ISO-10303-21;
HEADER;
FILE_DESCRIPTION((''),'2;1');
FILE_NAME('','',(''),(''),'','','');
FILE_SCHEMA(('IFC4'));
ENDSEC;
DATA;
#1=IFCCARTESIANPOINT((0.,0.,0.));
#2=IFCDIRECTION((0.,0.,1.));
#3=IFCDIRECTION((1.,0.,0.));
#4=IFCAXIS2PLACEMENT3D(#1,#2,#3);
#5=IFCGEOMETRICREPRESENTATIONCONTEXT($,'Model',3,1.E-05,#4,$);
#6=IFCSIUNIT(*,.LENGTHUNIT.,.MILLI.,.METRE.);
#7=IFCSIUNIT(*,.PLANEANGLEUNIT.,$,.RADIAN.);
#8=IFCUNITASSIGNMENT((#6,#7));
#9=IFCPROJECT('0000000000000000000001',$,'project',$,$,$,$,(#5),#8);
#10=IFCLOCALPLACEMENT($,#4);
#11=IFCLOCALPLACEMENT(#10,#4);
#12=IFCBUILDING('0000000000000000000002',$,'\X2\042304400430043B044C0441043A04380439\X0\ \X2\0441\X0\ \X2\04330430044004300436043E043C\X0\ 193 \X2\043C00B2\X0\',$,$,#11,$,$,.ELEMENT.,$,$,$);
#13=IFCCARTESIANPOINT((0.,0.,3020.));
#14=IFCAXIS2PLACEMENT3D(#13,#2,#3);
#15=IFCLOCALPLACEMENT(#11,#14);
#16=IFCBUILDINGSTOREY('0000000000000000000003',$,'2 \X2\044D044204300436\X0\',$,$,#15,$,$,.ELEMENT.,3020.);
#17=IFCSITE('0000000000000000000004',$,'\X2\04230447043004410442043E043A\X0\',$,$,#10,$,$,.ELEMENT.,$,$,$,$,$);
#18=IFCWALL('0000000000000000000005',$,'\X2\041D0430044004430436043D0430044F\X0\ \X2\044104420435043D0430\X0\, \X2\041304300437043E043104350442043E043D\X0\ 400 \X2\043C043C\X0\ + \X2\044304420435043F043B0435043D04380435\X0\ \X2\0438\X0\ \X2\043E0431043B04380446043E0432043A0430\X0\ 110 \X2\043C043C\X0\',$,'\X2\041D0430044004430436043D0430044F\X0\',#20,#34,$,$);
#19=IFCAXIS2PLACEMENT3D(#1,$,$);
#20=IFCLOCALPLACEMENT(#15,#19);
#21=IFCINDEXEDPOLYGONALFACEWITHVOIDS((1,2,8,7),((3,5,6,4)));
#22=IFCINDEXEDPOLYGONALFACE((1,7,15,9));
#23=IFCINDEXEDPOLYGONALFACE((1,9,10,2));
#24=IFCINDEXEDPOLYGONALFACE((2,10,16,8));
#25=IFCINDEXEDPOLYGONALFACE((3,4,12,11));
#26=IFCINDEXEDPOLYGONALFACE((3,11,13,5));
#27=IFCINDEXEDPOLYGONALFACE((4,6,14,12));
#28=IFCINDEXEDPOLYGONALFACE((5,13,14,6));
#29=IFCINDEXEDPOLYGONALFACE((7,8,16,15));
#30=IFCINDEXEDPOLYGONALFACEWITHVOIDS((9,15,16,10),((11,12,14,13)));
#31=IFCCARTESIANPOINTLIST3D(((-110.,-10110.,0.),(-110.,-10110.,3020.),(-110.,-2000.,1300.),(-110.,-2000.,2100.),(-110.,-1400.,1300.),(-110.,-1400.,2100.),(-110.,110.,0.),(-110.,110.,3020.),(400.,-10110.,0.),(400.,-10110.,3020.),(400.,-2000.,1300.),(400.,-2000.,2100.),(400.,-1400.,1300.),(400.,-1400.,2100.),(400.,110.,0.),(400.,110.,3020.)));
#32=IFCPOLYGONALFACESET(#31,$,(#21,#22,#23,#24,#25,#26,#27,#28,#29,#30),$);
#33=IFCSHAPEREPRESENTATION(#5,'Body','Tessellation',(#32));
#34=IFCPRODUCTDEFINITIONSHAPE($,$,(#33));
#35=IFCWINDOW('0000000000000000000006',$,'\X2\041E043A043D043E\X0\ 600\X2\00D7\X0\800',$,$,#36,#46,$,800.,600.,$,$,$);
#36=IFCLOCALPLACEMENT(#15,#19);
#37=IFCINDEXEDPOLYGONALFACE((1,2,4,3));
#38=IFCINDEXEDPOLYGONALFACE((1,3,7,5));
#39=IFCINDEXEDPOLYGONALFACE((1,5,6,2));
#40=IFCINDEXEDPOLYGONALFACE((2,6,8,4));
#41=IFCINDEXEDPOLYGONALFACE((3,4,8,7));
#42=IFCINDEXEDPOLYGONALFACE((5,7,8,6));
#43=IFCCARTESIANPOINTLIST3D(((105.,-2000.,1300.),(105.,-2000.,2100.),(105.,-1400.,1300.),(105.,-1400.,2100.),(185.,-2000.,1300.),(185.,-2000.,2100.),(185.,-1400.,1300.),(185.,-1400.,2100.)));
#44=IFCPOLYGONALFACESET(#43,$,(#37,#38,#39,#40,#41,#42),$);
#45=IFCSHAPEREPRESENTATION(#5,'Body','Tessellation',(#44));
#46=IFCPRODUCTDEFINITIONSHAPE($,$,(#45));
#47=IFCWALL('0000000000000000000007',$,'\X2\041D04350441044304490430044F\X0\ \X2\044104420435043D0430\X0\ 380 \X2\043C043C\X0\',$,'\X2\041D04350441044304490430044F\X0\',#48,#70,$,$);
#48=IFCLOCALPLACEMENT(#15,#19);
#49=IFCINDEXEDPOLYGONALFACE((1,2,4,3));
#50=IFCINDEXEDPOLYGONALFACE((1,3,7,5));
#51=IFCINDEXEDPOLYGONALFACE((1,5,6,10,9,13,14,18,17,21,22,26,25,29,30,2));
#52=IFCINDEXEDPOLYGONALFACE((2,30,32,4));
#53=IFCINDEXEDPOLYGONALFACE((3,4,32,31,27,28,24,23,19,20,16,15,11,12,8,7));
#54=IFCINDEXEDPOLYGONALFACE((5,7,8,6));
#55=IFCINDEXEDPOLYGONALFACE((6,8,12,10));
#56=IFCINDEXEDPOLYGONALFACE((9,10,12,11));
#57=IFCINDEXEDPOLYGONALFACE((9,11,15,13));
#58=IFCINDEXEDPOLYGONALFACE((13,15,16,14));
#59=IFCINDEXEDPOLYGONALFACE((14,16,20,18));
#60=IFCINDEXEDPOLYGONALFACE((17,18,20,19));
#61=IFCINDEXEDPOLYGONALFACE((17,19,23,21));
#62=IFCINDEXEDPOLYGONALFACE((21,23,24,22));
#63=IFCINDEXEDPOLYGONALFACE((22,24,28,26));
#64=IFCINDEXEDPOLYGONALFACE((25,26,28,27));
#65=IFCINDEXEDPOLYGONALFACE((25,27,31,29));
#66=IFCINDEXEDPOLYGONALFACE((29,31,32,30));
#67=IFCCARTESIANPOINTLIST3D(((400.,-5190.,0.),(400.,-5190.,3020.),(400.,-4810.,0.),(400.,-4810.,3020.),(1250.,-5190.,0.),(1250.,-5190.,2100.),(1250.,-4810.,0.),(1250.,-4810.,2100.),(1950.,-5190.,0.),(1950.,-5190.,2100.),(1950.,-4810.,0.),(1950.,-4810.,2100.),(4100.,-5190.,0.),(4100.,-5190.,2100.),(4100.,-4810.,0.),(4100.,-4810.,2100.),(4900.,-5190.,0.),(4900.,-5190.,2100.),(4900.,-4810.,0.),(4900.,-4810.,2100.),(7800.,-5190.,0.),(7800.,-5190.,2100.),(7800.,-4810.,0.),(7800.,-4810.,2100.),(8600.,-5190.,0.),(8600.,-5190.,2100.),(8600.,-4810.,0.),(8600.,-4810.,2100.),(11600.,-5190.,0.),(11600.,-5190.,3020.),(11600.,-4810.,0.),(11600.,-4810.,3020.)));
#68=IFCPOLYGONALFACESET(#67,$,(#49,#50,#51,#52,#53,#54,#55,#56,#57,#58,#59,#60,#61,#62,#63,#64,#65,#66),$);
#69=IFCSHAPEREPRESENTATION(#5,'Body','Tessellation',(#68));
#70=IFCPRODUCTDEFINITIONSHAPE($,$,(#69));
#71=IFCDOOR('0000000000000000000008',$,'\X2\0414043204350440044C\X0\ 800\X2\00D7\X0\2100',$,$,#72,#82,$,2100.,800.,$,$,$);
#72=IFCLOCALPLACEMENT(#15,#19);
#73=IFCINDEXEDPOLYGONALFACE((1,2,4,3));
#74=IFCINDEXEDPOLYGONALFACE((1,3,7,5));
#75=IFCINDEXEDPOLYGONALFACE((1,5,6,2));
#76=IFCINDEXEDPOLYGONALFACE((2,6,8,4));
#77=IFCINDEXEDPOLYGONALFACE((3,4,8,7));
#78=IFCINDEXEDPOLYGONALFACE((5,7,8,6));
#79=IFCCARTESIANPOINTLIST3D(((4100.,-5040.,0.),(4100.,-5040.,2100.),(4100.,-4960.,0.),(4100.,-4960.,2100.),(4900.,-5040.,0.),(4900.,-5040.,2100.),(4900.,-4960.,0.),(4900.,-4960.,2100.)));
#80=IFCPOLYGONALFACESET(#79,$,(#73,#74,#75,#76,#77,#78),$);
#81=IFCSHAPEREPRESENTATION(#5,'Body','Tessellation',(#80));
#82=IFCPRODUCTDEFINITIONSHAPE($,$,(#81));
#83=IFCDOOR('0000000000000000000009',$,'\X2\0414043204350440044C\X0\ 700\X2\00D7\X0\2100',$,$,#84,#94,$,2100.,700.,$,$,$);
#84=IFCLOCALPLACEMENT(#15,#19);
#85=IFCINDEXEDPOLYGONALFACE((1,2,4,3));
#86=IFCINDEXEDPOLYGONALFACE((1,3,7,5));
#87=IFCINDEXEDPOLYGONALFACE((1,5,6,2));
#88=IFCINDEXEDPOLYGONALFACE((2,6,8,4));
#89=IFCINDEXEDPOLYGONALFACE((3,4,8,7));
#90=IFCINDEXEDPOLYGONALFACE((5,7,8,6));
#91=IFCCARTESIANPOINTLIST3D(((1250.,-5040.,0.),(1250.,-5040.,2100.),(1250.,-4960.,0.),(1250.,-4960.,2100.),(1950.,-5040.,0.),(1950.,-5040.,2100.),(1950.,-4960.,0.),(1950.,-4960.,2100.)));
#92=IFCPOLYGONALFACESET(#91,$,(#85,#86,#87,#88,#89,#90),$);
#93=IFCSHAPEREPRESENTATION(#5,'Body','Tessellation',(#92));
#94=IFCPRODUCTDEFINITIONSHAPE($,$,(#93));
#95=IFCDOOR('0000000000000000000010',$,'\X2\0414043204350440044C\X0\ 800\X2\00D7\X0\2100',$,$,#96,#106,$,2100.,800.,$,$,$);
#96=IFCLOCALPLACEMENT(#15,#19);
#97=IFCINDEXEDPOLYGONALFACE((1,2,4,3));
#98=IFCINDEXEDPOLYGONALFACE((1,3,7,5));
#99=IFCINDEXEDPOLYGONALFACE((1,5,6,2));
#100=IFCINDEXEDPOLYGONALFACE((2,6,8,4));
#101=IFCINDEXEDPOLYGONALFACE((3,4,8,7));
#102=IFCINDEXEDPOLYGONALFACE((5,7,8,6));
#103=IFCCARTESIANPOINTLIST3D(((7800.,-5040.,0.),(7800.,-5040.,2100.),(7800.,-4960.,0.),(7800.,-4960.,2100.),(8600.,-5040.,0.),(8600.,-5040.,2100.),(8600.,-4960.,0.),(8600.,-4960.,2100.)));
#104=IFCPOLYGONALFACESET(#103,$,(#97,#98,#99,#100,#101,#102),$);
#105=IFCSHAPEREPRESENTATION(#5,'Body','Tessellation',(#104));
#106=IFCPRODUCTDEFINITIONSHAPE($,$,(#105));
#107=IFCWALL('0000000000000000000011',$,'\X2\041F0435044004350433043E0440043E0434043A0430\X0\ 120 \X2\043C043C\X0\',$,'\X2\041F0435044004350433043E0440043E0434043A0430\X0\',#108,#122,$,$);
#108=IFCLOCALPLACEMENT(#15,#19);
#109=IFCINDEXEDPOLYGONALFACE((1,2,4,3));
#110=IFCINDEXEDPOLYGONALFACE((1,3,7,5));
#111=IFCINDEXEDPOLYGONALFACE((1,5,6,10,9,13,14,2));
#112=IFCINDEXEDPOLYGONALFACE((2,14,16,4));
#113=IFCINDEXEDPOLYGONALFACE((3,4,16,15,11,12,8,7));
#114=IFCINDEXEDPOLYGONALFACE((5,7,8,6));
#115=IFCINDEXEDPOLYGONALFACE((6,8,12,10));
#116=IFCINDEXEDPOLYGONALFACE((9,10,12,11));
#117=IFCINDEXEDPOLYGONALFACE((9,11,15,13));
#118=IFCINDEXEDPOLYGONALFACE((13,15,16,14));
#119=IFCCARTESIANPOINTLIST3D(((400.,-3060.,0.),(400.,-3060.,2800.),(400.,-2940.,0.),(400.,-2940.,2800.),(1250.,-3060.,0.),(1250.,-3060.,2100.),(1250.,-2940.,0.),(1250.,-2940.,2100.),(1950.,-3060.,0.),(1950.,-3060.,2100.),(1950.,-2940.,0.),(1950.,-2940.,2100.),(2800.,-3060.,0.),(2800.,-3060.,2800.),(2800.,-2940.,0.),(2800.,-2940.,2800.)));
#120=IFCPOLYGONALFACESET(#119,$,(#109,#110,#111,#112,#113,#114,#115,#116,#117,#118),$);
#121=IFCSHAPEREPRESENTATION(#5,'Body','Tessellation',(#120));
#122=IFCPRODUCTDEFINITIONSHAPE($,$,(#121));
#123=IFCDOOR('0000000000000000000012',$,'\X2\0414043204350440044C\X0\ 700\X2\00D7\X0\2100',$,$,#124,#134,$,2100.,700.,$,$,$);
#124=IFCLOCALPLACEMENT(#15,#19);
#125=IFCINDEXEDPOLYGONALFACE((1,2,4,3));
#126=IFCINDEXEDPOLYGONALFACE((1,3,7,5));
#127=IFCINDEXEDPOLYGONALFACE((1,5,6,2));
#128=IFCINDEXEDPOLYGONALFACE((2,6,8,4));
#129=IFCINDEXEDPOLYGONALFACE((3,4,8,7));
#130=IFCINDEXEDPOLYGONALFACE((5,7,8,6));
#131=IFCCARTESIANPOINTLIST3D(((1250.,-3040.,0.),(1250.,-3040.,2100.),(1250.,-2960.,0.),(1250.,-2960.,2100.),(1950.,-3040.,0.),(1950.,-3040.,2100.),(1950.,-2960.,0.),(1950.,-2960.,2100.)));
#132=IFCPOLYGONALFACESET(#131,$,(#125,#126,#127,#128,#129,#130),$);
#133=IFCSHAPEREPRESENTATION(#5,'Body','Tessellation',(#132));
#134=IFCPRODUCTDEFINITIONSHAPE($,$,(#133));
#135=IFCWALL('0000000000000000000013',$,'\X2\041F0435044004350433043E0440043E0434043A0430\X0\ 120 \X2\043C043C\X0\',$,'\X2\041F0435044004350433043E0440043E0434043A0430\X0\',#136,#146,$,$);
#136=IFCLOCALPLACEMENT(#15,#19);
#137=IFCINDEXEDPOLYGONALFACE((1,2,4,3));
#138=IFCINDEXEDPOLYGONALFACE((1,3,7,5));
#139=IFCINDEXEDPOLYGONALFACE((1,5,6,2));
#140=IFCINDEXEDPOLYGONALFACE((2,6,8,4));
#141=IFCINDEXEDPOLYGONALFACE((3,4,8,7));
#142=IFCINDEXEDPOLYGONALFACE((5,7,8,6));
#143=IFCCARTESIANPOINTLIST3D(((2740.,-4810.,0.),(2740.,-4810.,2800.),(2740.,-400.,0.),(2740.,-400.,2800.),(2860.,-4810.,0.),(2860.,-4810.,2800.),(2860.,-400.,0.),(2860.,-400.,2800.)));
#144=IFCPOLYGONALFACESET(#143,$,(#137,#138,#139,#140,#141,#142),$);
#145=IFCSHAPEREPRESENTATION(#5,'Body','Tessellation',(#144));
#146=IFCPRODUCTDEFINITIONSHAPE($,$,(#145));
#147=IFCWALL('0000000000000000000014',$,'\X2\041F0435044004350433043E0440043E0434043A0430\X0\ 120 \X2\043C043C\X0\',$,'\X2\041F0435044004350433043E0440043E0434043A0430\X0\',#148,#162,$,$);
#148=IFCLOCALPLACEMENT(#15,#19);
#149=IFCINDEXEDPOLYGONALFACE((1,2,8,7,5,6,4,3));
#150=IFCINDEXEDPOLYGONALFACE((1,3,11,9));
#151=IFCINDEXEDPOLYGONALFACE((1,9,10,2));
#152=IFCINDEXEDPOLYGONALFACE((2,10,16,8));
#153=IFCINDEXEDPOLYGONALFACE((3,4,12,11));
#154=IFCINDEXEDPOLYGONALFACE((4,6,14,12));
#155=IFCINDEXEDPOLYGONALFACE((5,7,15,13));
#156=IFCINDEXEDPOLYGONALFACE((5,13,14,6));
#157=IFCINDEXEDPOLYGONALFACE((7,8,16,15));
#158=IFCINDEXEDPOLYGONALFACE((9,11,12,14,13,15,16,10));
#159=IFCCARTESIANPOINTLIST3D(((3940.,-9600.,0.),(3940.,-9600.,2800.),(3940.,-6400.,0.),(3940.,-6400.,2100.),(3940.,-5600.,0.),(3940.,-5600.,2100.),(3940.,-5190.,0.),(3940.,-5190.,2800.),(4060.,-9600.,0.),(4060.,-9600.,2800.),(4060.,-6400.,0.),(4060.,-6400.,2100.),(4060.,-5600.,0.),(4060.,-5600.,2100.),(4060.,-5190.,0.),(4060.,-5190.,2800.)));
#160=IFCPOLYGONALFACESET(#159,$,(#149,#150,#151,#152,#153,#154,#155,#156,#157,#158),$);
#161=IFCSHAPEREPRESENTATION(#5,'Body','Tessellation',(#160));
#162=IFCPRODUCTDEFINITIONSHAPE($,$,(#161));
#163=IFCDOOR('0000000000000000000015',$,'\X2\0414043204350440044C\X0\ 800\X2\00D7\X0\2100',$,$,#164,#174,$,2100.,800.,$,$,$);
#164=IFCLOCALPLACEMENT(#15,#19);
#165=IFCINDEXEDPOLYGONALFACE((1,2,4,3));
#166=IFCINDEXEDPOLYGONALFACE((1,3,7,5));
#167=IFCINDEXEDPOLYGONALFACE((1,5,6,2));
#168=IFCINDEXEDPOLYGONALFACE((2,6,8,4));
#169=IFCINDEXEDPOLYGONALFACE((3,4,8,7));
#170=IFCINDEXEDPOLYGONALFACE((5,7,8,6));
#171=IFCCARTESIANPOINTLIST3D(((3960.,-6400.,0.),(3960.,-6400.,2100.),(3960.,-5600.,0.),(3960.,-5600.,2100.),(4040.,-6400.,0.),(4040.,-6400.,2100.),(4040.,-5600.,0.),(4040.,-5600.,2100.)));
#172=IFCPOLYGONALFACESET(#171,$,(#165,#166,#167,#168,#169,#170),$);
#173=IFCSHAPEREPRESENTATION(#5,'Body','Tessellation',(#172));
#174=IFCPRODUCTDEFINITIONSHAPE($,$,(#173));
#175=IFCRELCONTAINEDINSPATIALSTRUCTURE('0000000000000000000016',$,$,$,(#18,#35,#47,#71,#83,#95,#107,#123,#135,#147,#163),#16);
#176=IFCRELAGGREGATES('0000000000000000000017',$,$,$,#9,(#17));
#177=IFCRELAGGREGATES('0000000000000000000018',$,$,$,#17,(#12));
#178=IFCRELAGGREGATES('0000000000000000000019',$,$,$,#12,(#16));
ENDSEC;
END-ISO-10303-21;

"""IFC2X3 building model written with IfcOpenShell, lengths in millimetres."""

from ifc_helpers import new_model, si_unit, frame, frame_2d, origin, origin_with_axes, place, context, project, spatial, rectangle, extrude, element, fill, save


model = new_model("IFC2X3")

# Units and contexts
model_context = context("Model", 3, precision=1e-05, world=origin_with_axes())
ifc_project = project(units=[si_unit("LENGTHUNIT", "METRE", prefix="MILLI"), si_unit("PLANEANGLEUNIT", "RADIAN")], contexts=[model_context])

# Site, building, storey
site_placement = place(None, origin_with_axes())
site = spatial("IfcSite", under=ifc_project, at=site_placement, Name="Участок", CompositionType="ELEMENT")
building_placement = place(site_placement, origin_with_axes())
building = spatial("IfcBuilding", under=site, at=building_placement, Name="Уральский с гаражом 193 м²", CompositionType="ELEMENT")
storey_placement = place(building_placement, frame((0.0, 0.0, 3020.0), z_axis=(0.0, 0.0, 1.0), x_axis=(1.0, 0.0, 0.0)))
storey = spatial("IfcBuildingStorey", under=building, at=storey_placement, Name="2 этаж", CompositionType="ELEMENT", Elevation=3020.0)

# Wall, opening, window
wall_1_placement = place(storey_placement, origin_with_axes())
wall_1 = element("IfcWall", 1, at=wall_1_placement, inside=storey, Name="Наружная стена, Газобетон 400 мм + утепление и облицовка 110 мм", ObjectType="Наружная", context=model_context, shape_type="SweptSolid", body=[
    extrude(rectangle(XDim=510.0, YDim=10220.0, at=frame_2d((145.0, -5000.0))), origin(), (0.0, 0.0, 1.0), 3020.0),
])
opening_1_placement = place(storey_placement, origin_with_axes())
opening_1 = element("IfcOpeningElement", 2, at=opening_1_placement, cuts=wall_1, ObjectType="Opening", context=model_context, shape_type="SweptSolid", body=[
    extrude(rectangle(XDim=530.0, YDim=600.0, at=frame_2d((145.0, -1700.0))), frame((0.0, 0.0, 1300.0)), (0.0, 0.0, 1.0), 800.0),
])
window_1_placement = place(storey_placement, origin_with_axes())
window_1 = element("IfcWindow", 3, at=window_1_placement, inside=storey, Name="Окно 600×800", OverallHeight=800.0, OverallWidth=600.0, context=model_context, shape_type="SweptSolid", body=[
    extrude(rectangle(XDim=80.0, YDim=600.0, at=frame_2d((145.0, -1700.0))), frame((0.0, 0.0, 1300.0)), (0.0, 0.0, 1.0), 800.0),
])
fill(opening_1, window_1)

# Wall, openings, doors
wall_2_placement = place(storey_placement, origin_with_axes())
wall_2 = element("IfcWall", 4, at=wall_2_placement, inside=storey, Name="Несущая стена 380 мм", ObjectType="Несущая", context=model_context, shape_type="SweptSolid", body=[
    extrude(rectangle(XDim=11200.0, YDim=380.0, at=frame_2d((6000.0, -5000.0))), origin(), (0.0, 0.0, 1.0), 3020.0),
])
opening_2_placement = place(storey_placement, origin_with_axes())
opening_2 = element("IfcOpeningElement", 5, at=opening_2_placement, cuts=wall_2, ObjectType="Opening", context=model_context, shape_type="SweptSolid", body=[
    extrude(rectangle(XDim=800.0, YDim=400.0, at=frame_2d((4500.0, -5000.0))), origin(), (0.0, 0.0, 1.0), 2100.0),
])
opening_3_placement = place(storey_placement, origin_with_axes())
opening_3 = element("IfcOpeningElement", 6, at=opening_3_placement, cuts=wall_2, ObjectType="Opening", context=model_context, shape_type="SweptSolid", body=[
    extrude(rectangle(XDim=700.0, YDim=400.0, at=frame_2d((1600.0, -5000.0))), origin(), (0.0, 0.0, 1.0), 2100.0),
])
opening_4_placement = place(storey_placement, origin_with_axes())
opening_4 = element("IfcOpeningElement", 7, at=opening_4_placement, cuts=wall_2, ObjectType="Opening", context=model_context, shape_type="SweptSolid", body=[
    extrude(rectangle(XDim=800.0, YDim=400.0, at=frame_2d((8200.0, -5000.0))), origin(), (0.0, 0.0, 1.0), 2100.0),
])
door_1_placement = place(storey_placement, origin_with_axes())
door_1 = element("IfcDoor", 8, at=door_1_placement, inside=storey, Name="Дверь 800×2100", OverallHeight=2100.0, OverallWidth=800.0, context=model_context, shape_type="SweptSolid", body=[
    extrude(rectangle(XDim=800.0, YDim=80.0, at=frame_2d((4500.0, -5000.0))), origin(), (0.0, 0.0, 1.0), 2100.0),
])
fill(opening_2, door_1)
door_2_placement = place(storey_placement, origin_with_axes())
door_2 = element("IfcDoor", 9, at=door_2_placement, inside=storey, Name="Дверь 700×2100", OverallHeight=2100.0, OverallWidth=700.0, context=model_context, shape_type="SweptSolid", body=[
    extrude(rectangle(XDim=700.0, YDim=80.0, at=frame_2d((1600.0, -5000.0))), origin(), (0.0, 0.0, 1.0), 2100.0),
])
fill(opening_3, door_2)
door_3_placement = place(storey_placement, origin_with_axes())
door_3 = element("IfcDoor", 10, at=door_3_placement, inside=storey, Name="Дверь 800×2100", OverallHeight=2100.0, OverallWidth=800.0, context=model_context, shape_type="SweptSolid", body=[
    extrude(rectangle(XDim=800.0, YDim=80.0, at=frame_2d((8200.0, -5000.0))), origin(), (0.0, 0.0, 1.0), 2100.0),
])
fill(opening_4, door_3)

# Wall, opening, door
wall_3_placement = place(storey_placement, origin_with_axes())
wall_3 = element("IfcWall", 11, at=wall_3_placement, inside=storey, Name="Перегородка 120 мм", ObjectType="Перегородка", context=model_context, shape_type="SweptSolid", body=[
    extrude(rectangle(XDim=2400.0, YDim=120.0, at=frame_2d((1600.0, -3000.0))), origin(), (0.0, 0.0, 1.0), 2800.0),
])
opening_5_placement = place(storey_placement, origin_with_axes())
opening_5 = element("IfcOpeningElement", 12, at=opening_5_placement, cuts=wall_3, ObjectType="Opening", context=model_context, shape_type="SweptSolid", body=[
    extrude(rectangle(XDim=700.0, YDim=140.0, at=frame_2d((1600.0, -3000.0))), origin(), (0.0, 0.0, 1.0), 2100.0),
])
door_4_placement = place(storey_placement, origin_with_axes())
door_4 = element("IfcDoor", 13, at=door_4_placement, inside=storey, Name="Дверь 700×2100", OverallHeight=2100.0, OverallWidth=700.0, context=model_context, shape_type="SweptSolid", body=[
    extrude(rectangle(XDim=700.0, YDim=80.0, at=frame_2d((1600.0, -3000.0))), origin(), (0.0, 0.0, 1.0), 2100.0),
])
fill(opening_5, door_4)

# Wall
wall_4_placement = place(storey_placement, origin_with_axes())
element("IfcWall", 14, at=wall_4_placement, inside=storey, Name="Перегородка 120 мм", ObjectType="Перегородка", context=model_context, shape_type="SweptSolid", body=[
    extrude(rectangle(XDim=120.0, YDim=4410.0, at=frame_2d((2800.0, -2605.0))), origin(), (0.0, 0.0, 1.0), 2800.0),
])

# Wall, opening, door
wall_5_placement = place(storey_placement, origin_with_axes())
wall_5 = element("IfcWall", 15, at=wall_5_placement, inside=storey, Name="Перегородка 120 мм", ObjectType="Перегородка", context=model_context, shape_type="SweptSolid", body=[
    extrude(rectangle(XDim=120.0, YDim=4410.0, at=frame_2d((4000.0, -7395.0))), origin(), (0.0, 0.0, 1.0), 2800.0),
])
opening_6_placement = place(storey_placement, origin_with_axes())
opening_6 = element("IfcOpeningElement", 16, at=opening_6_placement, cuts=wall_5, ObjectType="Opening", context=model_context, shape_type="SweptSolid", body=[
    extrude(rectangle(XDim=140.0, YDim=800.0, at=frame_2d((4000.0, -6000.0))), origin(), (0.0, 0.0, 1.0), 2100.0),
])
door_5_placement = place(storey_placement, origin_with_axes())
door_5 = element("IfcDoor", 17, at=door_5_placement, inside=storey, Name="Дверь 800×2100", OverallHeight=2100.0, OverallWidth=800.0, context=model_context, shape_type="SweptSolid", body=[
    extrude(rectangle(XDim=80.0, YDim=800.0, at=frame_2d((4000.0, -6000.0))), origin(), (0.0, 0.0, 1.0), 2100.0),
])
fill(opening_6, door_5)

save(model, "model.ifc")
